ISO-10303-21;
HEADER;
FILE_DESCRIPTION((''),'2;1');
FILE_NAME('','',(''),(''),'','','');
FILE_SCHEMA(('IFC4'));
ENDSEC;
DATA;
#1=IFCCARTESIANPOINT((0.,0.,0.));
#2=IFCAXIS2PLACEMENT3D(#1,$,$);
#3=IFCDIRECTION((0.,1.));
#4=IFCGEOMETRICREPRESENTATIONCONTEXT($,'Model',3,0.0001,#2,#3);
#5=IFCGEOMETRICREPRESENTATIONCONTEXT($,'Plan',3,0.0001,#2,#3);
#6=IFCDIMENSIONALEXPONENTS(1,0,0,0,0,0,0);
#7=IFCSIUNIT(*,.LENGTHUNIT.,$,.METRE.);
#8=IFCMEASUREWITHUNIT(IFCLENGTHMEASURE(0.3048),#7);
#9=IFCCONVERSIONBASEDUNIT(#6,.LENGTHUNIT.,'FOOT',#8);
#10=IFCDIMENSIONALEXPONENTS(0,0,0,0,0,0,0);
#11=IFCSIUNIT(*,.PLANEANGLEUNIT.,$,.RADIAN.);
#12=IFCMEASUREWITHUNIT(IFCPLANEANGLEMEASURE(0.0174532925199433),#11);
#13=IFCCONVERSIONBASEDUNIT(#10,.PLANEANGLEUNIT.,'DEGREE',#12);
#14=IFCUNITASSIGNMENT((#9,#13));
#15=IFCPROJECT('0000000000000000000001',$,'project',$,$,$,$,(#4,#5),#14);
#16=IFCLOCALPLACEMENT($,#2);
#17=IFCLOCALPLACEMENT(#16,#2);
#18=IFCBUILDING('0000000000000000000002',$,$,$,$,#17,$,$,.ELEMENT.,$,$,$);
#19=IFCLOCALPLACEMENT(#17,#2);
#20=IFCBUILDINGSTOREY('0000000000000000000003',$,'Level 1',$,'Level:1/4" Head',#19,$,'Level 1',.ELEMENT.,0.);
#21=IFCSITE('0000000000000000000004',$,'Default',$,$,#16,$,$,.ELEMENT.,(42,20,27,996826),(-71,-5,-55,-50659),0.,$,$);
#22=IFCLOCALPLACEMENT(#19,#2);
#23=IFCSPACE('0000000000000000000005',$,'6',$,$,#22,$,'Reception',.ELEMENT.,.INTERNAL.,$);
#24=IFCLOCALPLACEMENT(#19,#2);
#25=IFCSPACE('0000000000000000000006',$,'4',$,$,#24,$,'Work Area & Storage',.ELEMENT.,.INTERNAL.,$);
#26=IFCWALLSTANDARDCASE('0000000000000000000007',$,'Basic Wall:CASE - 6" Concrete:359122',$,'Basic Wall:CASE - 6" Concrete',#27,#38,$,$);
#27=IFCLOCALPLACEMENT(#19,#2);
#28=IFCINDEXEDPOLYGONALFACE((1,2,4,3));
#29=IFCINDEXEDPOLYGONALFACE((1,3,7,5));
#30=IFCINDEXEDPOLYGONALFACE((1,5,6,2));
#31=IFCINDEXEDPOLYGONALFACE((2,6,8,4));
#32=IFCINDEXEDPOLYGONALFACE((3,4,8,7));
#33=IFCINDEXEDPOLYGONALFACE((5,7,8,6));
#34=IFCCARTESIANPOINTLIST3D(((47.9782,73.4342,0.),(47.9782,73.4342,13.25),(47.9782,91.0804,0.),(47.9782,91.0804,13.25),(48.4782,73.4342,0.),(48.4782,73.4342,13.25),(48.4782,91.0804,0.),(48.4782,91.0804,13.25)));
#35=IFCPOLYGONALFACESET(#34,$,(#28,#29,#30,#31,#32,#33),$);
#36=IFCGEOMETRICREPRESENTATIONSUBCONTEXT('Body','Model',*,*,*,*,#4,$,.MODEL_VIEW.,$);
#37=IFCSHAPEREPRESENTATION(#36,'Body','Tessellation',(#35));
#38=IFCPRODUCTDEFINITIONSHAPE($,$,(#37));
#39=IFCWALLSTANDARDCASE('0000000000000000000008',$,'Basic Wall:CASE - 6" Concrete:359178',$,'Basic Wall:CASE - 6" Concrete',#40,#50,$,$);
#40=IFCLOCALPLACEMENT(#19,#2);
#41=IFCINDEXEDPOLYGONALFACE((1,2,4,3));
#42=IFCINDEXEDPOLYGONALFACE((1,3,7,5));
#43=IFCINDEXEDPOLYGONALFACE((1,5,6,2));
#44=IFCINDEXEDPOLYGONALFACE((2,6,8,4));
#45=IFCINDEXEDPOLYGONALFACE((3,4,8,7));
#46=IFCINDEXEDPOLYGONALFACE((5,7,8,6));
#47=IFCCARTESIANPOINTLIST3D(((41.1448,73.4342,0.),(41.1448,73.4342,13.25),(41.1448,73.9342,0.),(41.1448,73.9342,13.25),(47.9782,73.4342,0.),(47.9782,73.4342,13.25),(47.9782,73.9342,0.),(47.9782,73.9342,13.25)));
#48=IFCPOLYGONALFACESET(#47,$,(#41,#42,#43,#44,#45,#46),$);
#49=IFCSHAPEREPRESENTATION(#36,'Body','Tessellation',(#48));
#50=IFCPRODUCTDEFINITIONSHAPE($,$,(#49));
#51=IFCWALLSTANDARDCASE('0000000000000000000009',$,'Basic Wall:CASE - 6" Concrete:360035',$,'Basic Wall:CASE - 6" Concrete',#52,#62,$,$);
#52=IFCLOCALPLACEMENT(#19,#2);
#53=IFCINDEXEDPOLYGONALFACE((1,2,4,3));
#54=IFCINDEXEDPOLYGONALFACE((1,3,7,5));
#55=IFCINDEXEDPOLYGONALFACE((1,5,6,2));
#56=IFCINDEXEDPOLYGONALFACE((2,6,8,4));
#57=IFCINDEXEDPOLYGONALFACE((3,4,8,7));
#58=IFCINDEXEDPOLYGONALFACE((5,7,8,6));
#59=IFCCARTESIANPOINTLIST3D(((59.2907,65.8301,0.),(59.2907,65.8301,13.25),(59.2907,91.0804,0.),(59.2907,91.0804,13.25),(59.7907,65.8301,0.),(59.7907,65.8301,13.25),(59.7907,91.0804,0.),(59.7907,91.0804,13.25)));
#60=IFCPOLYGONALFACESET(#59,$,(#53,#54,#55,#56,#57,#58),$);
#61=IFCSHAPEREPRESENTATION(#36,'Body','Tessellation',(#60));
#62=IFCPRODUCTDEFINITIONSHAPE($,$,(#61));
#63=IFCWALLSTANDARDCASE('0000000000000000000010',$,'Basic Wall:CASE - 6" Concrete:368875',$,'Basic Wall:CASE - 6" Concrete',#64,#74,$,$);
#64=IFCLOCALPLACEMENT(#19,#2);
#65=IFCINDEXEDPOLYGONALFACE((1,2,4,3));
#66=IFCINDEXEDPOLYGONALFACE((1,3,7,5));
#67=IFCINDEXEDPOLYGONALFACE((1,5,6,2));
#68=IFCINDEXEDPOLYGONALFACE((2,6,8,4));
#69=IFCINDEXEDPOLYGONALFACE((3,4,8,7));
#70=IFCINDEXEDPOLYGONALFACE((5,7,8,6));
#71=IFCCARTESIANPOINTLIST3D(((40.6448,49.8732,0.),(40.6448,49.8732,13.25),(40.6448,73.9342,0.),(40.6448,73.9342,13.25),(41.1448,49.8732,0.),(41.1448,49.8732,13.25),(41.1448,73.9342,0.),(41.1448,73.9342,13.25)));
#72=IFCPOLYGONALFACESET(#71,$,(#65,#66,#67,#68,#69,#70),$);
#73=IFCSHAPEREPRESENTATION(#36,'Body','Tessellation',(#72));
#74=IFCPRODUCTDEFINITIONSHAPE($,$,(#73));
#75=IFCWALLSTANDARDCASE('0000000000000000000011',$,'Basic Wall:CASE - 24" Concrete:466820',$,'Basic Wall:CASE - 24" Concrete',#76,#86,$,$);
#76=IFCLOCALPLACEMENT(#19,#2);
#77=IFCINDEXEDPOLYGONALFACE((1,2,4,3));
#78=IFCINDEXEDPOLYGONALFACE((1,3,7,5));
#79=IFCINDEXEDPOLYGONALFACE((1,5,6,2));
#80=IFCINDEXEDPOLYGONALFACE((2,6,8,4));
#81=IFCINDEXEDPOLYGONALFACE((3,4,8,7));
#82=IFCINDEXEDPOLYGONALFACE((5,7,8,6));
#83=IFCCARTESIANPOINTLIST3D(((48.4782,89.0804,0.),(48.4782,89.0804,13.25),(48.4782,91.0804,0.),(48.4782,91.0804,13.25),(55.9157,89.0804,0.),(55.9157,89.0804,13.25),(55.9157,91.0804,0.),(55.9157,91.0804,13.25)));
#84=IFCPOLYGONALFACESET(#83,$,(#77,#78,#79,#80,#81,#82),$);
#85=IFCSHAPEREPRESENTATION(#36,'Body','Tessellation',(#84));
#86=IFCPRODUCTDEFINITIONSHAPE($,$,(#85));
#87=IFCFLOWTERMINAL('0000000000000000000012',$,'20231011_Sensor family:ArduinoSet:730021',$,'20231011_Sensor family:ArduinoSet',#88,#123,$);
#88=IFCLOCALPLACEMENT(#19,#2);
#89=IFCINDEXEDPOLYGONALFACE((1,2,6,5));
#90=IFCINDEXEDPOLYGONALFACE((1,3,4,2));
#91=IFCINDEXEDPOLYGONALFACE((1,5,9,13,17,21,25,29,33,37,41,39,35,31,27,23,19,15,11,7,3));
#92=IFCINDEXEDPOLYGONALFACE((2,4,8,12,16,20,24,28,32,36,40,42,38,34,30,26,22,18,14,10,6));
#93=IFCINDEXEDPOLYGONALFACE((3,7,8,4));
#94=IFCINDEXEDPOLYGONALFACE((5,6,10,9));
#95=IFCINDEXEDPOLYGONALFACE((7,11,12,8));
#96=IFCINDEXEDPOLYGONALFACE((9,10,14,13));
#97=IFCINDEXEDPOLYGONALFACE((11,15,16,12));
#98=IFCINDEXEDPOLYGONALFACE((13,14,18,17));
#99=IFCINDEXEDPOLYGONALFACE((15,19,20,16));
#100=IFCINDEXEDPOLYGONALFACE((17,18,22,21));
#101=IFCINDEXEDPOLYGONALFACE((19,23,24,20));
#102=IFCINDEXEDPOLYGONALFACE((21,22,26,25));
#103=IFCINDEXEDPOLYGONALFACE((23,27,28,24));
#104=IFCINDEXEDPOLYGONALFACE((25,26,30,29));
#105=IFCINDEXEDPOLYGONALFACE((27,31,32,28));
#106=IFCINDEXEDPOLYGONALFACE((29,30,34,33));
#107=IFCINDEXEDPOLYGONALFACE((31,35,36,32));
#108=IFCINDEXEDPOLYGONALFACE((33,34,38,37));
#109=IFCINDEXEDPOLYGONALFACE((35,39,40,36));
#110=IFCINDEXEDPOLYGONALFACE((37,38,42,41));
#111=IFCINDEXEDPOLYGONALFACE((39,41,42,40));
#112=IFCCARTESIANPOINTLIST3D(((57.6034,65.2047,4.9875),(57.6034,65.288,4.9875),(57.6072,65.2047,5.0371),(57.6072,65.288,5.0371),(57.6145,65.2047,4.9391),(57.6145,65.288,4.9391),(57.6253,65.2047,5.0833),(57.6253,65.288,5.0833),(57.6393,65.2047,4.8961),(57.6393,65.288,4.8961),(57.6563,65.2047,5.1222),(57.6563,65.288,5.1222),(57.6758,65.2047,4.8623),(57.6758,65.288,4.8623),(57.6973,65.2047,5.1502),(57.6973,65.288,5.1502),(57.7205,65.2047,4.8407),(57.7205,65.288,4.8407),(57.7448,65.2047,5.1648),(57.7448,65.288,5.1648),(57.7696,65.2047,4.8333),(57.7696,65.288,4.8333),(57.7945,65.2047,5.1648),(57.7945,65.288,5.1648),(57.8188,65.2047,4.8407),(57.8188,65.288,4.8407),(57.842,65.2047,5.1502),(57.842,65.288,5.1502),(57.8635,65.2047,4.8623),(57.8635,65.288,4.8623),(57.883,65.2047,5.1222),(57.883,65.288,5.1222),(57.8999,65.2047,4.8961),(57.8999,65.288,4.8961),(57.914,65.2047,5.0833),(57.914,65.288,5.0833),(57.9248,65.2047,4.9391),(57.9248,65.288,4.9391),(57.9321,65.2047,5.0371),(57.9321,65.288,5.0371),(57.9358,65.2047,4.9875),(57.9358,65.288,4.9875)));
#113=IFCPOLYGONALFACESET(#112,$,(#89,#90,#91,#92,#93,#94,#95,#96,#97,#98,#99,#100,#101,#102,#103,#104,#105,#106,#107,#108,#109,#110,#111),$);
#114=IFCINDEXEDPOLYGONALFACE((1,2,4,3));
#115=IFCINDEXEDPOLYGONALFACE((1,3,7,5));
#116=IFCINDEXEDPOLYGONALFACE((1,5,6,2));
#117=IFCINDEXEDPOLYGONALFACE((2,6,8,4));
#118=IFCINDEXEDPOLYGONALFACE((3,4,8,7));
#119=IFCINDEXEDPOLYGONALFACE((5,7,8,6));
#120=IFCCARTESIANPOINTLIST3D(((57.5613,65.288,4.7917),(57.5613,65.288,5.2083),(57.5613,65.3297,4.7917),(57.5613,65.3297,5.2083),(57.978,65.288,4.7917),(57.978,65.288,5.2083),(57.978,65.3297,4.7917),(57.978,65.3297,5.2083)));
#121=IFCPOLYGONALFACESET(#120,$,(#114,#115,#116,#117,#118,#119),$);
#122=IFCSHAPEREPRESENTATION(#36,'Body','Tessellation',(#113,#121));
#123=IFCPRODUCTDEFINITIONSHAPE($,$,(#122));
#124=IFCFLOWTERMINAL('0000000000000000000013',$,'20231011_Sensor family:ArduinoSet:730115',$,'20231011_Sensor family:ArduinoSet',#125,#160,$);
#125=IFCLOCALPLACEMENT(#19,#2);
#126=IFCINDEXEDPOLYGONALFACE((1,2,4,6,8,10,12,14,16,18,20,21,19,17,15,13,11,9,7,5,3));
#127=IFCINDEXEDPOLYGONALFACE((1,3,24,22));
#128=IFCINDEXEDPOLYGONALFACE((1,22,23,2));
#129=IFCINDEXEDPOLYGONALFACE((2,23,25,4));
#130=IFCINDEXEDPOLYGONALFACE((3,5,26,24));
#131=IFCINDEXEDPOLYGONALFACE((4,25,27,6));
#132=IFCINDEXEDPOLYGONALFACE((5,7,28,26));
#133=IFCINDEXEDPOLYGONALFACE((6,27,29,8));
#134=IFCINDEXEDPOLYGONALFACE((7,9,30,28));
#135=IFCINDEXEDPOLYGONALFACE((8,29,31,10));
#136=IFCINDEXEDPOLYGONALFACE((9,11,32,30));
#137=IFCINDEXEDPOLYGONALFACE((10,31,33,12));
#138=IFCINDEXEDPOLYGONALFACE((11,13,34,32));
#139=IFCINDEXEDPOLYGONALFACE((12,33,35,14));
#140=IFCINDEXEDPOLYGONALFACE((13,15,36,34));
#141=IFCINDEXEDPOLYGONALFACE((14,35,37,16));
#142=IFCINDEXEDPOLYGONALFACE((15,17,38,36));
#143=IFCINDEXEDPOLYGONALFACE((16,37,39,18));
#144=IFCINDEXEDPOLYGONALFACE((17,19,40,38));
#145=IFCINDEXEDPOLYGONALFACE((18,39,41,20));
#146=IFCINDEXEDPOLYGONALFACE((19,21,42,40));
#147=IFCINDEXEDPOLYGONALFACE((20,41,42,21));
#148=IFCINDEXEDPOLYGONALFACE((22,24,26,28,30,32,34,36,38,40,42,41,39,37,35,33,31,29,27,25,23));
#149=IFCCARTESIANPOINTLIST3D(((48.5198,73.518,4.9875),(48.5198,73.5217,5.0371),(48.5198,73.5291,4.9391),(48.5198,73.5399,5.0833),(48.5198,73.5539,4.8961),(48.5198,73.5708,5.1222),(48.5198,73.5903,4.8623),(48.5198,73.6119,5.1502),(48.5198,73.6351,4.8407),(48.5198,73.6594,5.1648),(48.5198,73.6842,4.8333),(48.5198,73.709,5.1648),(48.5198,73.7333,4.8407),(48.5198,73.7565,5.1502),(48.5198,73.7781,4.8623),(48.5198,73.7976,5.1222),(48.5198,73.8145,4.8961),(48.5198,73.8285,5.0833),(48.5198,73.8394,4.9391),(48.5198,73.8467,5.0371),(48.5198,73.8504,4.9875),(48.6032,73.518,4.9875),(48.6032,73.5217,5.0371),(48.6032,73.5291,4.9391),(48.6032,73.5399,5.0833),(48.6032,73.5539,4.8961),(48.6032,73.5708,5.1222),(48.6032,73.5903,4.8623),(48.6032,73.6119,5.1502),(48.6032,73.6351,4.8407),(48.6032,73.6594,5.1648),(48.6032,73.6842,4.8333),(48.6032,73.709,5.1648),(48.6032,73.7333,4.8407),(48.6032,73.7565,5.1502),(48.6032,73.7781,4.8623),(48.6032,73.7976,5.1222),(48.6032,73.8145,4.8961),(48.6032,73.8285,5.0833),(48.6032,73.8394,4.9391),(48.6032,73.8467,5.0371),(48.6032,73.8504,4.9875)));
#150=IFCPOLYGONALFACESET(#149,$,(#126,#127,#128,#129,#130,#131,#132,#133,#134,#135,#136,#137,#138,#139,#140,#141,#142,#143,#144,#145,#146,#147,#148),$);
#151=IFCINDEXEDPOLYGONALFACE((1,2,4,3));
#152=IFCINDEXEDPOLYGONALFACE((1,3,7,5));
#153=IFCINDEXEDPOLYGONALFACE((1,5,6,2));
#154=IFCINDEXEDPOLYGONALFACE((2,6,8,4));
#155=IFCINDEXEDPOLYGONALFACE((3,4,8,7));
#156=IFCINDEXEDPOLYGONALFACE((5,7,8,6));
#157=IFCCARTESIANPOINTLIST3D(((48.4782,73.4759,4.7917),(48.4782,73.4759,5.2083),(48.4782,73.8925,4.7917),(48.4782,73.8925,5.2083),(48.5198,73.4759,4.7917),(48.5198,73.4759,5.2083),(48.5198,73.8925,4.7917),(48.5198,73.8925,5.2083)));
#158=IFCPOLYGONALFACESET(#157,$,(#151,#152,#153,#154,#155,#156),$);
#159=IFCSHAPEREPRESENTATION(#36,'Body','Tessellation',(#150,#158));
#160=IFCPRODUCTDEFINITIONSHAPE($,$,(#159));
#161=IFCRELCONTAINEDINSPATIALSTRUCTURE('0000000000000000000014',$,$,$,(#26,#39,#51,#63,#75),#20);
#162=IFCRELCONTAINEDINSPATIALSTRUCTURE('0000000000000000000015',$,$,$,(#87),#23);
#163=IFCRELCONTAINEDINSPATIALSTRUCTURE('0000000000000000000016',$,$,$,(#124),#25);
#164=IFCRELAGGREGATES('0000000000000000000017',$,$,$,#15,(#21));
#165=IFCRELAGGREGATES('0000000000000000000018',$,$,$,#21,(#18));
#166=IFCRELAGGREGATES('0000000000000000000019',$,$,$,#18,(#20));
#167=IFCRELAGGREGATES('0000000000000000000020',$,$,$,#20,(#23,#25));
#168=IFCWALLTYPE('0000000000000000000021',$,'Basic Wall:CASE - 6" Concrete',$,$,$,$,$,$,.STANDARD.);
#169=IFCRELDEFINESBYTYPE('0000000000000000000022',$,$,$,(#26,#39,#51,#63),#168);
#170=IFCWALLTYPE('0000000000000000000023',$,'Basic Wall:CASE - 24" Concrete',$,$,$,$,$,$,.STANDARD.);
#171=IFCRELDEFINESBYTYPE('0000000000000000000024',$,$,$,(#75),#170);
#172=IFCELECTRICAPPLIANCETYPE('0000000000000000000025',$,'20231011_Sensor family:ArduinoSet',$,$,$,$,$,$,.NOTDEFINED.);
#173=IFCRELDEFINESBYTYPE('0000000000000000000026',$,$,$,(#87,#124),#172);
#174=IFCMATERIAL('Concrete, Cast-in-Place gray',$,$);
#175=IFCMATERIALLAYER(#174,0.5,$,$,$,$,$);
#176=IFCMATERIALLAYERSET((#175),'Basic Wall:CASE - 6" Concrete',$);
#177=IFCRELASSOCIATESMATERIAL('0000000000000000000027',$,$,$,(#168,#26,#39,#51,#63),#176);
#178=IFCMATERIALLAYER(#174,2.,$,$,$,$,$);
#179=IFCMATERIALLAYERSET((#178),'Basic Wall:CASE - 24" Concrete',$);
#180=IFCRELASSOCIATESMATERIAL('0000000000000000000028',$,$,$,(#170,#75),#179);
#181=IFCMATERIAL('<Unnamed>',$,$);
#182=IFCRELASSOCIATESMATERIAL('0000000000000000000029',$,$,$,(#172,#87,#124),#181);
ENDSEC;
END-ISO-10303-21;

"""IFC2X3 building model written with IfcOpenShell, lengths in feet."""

from ifc_helpers import new_model, entity, si_unit, converted_unit, direction, frame, frame_2d, origin, origin_2d_with_axis, place, context, subcontext, project, spatial, rectangle, circle, extrude, source, transform, mapped, material, layer, layer_set, layer_usage, type_object, type_shapes, element, save


model = new_model("IFC2X3")

# Units and contexts
model_context = context("Model", 3, precision=0.0001, world=origin(), true_north=direction((0.0, 1.0)))
plan_context = context("Plan", 3, precision=0.0001, world=origin(), true_north=direction((0.0, 1.0)))
body_context = subcontext(model_context, "Body", "Model", "MODEL_VIEW")
ifc_project = project(units=[converted_unit("LENGTHUNIT", "FOOT", entity("IfcLengthMeasure", 0.3048), si_unit("LENGTHUNIT", "METRE"), dimensions=[1, 0, 0, 0, 0, 0, 0]), converted_unit("PLANEANGLEUNIT", "DEGREE", entity("IfcPlaneAngleMeasure", 0.0174532925199433), si_unit("PLANEANGLEUNIT", "RADIAN"), dimensions=[0, 0, 0, 0, 0, 0, 0])], contexts=[model_context, plan_context])

# Site, building, storey
site_placement = place(None, origin())
site = spatial("IfcSite", under=ifc_project, at=site_placement, Name="Default", CompositionType="ELEMENT", RefLatitude=(42, 20, 27, 996826), RefLongitude=(-71, -5, -55, -50659), RefElevation=0.0)
building_placement = place(site_placement, origin())
building = spatial("IfcBuilding", under=site, at=building_placement, CompositionType="ELEMENT")
storey_placement = place(building_placement, origin())
storey = spatial("IfcBuildingStorey", under=building, at=storey_placement, Name="Level 1", ObjectType="Level:1/4\" Head", LongName="Level 1", CompositionType="ELEMENT", Elevation=0.0)

# Walls
ifc_material_1 = material(Name="Concrete, Cast-in-Place gray")
ifc_layer_1 = layer(ifc_material_1, 0.5)
ifc_layer_set_1 = layer_set([ifc_layer_1], Name="Basic Wall:CASE - 6\" Concrete")
ifc_layer_usage_1 = layer_usage(ifc_layer_set_1, "AXIS2", "NEGATIVE", 0.25)
wall_type_1 = type_object("IfcWallType", Name="Basic Wall:CASE - 6\" Concrete", PredefinedType="STANDARD", material=ifc_layer_set_1)
wall_1_placement = place(storey_placement, frame((48.2282, 91.0804, 0.0), z_axis=(0.0, 0.0, 1.0), x_axis=(0.0, -1.0, 0.0)))
element("IfcWallStandardCase", 1, at=wall_1_placement, inside=storey, type_object=wall_type_1, material=ifc_layer_usage_1, Name="Basic Wall:CASE - 6\" Concrete:359122", ObjectType="Basic Wall:CASE - 6\" Concrete", context=body_context, shape_type="SweptSolid", body=[
    extrude(rectangle(XDim=17.6462, YDim=0.5, at=frame_2d((8.8231, 0.0), x_axis=(-1.0, 0.0))), origin(), (0.0, 0.0, 1.0), 13.25),
])
ifc_layer_usage_2 = layer_usage(ifc_layer_set_1, "AXIS2", "NEGATIVE", 0.25)
wall_2_placement = place(storey_placement, frame((47.9782, 73.6842, 0.0), z_axis=(0.0, 0.0, 1.0), x_axis=(-1.0, 0.0, 0.0)))
element("IfcWallStandardCase", 2, at=wall_2_placement, inside=storey, type_object=wall_type_1, material=ifc_layer_usage_2, Name="Basic Wall:CASE - 6\" Concrete:359178", ObjectType="Basic Wall:CASE - 6\" Concrete", context=body_context, shape_type="SweptSolid", body=[
    extrude(rectangle(XDim=6.8333, YDim=0.5, at=frame_2d((3.4167, 0.0), x_axis=(-1.0, 0.0))), origin(), (0.0, 0.0, 1.0), 13.25),
])
ifc_layer_usage_3 = layer_usage(ifc_layer_set_1, "AXIS2", "NEGATIVE", 0.25)
wall_3_placement = place(storey_placement, frame((59.5407, 65.8301, 0.0), z_axis=(0.0, 0.0, 1.0), x_axis=(0.0, 1.0, 0.0)))
element("IfcWallStandardCase", 3, at=wall_3_placement, inside=storey, type_object=wall_type_1, material=ifc_layer_usage_3, Name="Basic Wall:CASE - 6\" Concrete:360035", ObjectType="Basic Wall:CASE - 6\" Concrete", context=body_context, shape_type="SweptSolid", body=[
    extrude(rectangle(XDim=25.2502, YDim=0.5, at=frame_2d((12.6251, 0.0), x_axis=(-1.0, 0.0))), origin(), (0.0, 0.0, 1.0), 13.25),
])
ifc_layer_usage_4 = layer_usage(ifc_layer_set_1, "AXIS2", "NEGATIVE", 0.25)
wall_4_placement = place(storey_placement, frame((40.8948, 73.9342, 0.0), z_axis=(0.0, 0.0, 1.0), x_axis=(0.0, -1.0, 0.0)))
element("IfcWallStandardCase", 4, at=wall_4_placement, inside=storey, type_object=wall_type_1, material=ifc_layer_usage_4, Name="Basic Wall:CASE - 6\" Concrete:368875", ObjectType="Basic Wall:CASE - 6\" Concrete", context=body_context, shape_type="SweptSolid", body=[
    extrude(rectangle(XDim=24.061, YDim=0.5, at=frame_2d((12.0305, 0.0), x_axis=(-1.0, 0.0))), origin(), (0.0, 0.0, 1.0), 13.25),
])
ifc_layer_2 = layer(ifc_material_1, 2.0)
ifc_layer_set_2 = layer_set([ifc_layer_2], Name="Basic Wall:CASE - 24\" Concrete")
ifc_layer_usage_5 = layer_usage(ifc_layer_set_2, "AXIS2", "NEGATIVE", 1.0)
wall_type_2 = type_object("IfcWallType", Name="Basic Wall:CASE - 24\" Concrete", PredefinedType="STANDARD", material=ifc_layer_set_2)
wall_5_placement = place(storey_placement, frame((48.4782, 90.0804, 0.0)))
element("IfcWallStandardCase", 5, at=wall_5_placement, inside=storey, type_object=wall_type_2, material=ifc_layer_usage_5, Name="Basic Wall:CASE - 24\" Concrete:466820", ObjectType="Basic Wall:CASE - 24\" Concrete", context=body_context, shape_type="SweptSolid", body=[
    extrude(rectangle(XDim=7.4375, YDim=2.0, at=frame_2d((3.7187, 0.0), x_axis=(-1.0, 0.0))), origin(), (0.0, 0.0, 1.0), 13.25),
])

# Shared definitions
space_1_placement = place(storey_placement, origin())
space_1 = spatial("IfcSpace", under=storey, at=space_1_placement, Name="6", LongName="Reception", CompositionType="ELEMENT", InteriorOrExteriorSpace="INTERNAL")

# Flow terminal
ifc_material_2 = material(Name="<Unnamed>")
electric_appliance_type = type_object("IfcElectricApplianceType", Name="20231011_Sensor family:ArduinoSet", PredefinedType="NOTDEFINED", material=ifc_material_2)
shared_shape_1 = source(origin(), body_context, "Body", "SweptSolid", [
    extrude(circle(Radius=0.1667, at=frame_2d((0.0, 0.0), x_axis=(1.0, 0.0))), frame((0.0417, 0.0, 0.0), z_axis=(1.0, 0.0, 0.0), x_axis=(0.0, 0.0, -1.0)), (0.0, 0.0, 1.0), 0.0833),
    extrude(rectangle(XDim=0.0417, YDim=0.4167, at=origin_2d_with_axis()), frame((0.0208, 0.0, -0.2083), z_axis=(0.0, 0.0, 1.0), x_axis=(-1.0, 0.0, 0.0)), (0.0, 0.0, 1.0), 0.4167),
])
type_shapes(electric_appliance_type, [shared_shape_1])
flow_terminal_1_placement = place(space_1_placement, frame((57.7696, 65.3297, 5.0), z_axis=(0.0, 0.0, 1.0), x_axis=(0.0, -1.0, 0.0)))
element("IfcFlowTerminal", 6, at=flow_terminal_1_placement, inside=space_1, type_object=electric_appliance_type, material=ifc_material_2, Name="20231011_Sensor family:ArduinoSet:730021", ObjectType="20231011_Sensor family:ArduinoSet", context=body_context, shape_type="MappedRepresentation", body=[
    mapped(shared_shape_1, transform((0.0, 0.0, 0.0), scale=1.0)),
])

# Shared definitions
space_2_placement = place(storey_placement, origin())
space_2 = spatial("IfcSpace", under=storey, at=space_2_placement, Name="4", LongName="Work Area & Storage", CompositionType="ELEMENT", InteriorOrExteriorSpace="INTERNAL")

# Flow terminal
flow_terminal_2_placement = place(space_2_placement, frame((48.4782, 73.6842, 5.0)))
element("IfcFlowTerminal", 7, at=flow_terminal_2_placement, inside=space_2, type_object=electric_appliance_type, material=ifc_material_2, Name="20231011_Sensor family:ArduinoSet:730115", ObjectType="20231011_Sensor family:ArduinoSet", context=body_context, shape_type="MappedRepresentation", body=[
    mapped(shared_shape_1, transform((0.0, 0.0, 0.0), scale=1.0)),
])

save(model, "model.ifc")
